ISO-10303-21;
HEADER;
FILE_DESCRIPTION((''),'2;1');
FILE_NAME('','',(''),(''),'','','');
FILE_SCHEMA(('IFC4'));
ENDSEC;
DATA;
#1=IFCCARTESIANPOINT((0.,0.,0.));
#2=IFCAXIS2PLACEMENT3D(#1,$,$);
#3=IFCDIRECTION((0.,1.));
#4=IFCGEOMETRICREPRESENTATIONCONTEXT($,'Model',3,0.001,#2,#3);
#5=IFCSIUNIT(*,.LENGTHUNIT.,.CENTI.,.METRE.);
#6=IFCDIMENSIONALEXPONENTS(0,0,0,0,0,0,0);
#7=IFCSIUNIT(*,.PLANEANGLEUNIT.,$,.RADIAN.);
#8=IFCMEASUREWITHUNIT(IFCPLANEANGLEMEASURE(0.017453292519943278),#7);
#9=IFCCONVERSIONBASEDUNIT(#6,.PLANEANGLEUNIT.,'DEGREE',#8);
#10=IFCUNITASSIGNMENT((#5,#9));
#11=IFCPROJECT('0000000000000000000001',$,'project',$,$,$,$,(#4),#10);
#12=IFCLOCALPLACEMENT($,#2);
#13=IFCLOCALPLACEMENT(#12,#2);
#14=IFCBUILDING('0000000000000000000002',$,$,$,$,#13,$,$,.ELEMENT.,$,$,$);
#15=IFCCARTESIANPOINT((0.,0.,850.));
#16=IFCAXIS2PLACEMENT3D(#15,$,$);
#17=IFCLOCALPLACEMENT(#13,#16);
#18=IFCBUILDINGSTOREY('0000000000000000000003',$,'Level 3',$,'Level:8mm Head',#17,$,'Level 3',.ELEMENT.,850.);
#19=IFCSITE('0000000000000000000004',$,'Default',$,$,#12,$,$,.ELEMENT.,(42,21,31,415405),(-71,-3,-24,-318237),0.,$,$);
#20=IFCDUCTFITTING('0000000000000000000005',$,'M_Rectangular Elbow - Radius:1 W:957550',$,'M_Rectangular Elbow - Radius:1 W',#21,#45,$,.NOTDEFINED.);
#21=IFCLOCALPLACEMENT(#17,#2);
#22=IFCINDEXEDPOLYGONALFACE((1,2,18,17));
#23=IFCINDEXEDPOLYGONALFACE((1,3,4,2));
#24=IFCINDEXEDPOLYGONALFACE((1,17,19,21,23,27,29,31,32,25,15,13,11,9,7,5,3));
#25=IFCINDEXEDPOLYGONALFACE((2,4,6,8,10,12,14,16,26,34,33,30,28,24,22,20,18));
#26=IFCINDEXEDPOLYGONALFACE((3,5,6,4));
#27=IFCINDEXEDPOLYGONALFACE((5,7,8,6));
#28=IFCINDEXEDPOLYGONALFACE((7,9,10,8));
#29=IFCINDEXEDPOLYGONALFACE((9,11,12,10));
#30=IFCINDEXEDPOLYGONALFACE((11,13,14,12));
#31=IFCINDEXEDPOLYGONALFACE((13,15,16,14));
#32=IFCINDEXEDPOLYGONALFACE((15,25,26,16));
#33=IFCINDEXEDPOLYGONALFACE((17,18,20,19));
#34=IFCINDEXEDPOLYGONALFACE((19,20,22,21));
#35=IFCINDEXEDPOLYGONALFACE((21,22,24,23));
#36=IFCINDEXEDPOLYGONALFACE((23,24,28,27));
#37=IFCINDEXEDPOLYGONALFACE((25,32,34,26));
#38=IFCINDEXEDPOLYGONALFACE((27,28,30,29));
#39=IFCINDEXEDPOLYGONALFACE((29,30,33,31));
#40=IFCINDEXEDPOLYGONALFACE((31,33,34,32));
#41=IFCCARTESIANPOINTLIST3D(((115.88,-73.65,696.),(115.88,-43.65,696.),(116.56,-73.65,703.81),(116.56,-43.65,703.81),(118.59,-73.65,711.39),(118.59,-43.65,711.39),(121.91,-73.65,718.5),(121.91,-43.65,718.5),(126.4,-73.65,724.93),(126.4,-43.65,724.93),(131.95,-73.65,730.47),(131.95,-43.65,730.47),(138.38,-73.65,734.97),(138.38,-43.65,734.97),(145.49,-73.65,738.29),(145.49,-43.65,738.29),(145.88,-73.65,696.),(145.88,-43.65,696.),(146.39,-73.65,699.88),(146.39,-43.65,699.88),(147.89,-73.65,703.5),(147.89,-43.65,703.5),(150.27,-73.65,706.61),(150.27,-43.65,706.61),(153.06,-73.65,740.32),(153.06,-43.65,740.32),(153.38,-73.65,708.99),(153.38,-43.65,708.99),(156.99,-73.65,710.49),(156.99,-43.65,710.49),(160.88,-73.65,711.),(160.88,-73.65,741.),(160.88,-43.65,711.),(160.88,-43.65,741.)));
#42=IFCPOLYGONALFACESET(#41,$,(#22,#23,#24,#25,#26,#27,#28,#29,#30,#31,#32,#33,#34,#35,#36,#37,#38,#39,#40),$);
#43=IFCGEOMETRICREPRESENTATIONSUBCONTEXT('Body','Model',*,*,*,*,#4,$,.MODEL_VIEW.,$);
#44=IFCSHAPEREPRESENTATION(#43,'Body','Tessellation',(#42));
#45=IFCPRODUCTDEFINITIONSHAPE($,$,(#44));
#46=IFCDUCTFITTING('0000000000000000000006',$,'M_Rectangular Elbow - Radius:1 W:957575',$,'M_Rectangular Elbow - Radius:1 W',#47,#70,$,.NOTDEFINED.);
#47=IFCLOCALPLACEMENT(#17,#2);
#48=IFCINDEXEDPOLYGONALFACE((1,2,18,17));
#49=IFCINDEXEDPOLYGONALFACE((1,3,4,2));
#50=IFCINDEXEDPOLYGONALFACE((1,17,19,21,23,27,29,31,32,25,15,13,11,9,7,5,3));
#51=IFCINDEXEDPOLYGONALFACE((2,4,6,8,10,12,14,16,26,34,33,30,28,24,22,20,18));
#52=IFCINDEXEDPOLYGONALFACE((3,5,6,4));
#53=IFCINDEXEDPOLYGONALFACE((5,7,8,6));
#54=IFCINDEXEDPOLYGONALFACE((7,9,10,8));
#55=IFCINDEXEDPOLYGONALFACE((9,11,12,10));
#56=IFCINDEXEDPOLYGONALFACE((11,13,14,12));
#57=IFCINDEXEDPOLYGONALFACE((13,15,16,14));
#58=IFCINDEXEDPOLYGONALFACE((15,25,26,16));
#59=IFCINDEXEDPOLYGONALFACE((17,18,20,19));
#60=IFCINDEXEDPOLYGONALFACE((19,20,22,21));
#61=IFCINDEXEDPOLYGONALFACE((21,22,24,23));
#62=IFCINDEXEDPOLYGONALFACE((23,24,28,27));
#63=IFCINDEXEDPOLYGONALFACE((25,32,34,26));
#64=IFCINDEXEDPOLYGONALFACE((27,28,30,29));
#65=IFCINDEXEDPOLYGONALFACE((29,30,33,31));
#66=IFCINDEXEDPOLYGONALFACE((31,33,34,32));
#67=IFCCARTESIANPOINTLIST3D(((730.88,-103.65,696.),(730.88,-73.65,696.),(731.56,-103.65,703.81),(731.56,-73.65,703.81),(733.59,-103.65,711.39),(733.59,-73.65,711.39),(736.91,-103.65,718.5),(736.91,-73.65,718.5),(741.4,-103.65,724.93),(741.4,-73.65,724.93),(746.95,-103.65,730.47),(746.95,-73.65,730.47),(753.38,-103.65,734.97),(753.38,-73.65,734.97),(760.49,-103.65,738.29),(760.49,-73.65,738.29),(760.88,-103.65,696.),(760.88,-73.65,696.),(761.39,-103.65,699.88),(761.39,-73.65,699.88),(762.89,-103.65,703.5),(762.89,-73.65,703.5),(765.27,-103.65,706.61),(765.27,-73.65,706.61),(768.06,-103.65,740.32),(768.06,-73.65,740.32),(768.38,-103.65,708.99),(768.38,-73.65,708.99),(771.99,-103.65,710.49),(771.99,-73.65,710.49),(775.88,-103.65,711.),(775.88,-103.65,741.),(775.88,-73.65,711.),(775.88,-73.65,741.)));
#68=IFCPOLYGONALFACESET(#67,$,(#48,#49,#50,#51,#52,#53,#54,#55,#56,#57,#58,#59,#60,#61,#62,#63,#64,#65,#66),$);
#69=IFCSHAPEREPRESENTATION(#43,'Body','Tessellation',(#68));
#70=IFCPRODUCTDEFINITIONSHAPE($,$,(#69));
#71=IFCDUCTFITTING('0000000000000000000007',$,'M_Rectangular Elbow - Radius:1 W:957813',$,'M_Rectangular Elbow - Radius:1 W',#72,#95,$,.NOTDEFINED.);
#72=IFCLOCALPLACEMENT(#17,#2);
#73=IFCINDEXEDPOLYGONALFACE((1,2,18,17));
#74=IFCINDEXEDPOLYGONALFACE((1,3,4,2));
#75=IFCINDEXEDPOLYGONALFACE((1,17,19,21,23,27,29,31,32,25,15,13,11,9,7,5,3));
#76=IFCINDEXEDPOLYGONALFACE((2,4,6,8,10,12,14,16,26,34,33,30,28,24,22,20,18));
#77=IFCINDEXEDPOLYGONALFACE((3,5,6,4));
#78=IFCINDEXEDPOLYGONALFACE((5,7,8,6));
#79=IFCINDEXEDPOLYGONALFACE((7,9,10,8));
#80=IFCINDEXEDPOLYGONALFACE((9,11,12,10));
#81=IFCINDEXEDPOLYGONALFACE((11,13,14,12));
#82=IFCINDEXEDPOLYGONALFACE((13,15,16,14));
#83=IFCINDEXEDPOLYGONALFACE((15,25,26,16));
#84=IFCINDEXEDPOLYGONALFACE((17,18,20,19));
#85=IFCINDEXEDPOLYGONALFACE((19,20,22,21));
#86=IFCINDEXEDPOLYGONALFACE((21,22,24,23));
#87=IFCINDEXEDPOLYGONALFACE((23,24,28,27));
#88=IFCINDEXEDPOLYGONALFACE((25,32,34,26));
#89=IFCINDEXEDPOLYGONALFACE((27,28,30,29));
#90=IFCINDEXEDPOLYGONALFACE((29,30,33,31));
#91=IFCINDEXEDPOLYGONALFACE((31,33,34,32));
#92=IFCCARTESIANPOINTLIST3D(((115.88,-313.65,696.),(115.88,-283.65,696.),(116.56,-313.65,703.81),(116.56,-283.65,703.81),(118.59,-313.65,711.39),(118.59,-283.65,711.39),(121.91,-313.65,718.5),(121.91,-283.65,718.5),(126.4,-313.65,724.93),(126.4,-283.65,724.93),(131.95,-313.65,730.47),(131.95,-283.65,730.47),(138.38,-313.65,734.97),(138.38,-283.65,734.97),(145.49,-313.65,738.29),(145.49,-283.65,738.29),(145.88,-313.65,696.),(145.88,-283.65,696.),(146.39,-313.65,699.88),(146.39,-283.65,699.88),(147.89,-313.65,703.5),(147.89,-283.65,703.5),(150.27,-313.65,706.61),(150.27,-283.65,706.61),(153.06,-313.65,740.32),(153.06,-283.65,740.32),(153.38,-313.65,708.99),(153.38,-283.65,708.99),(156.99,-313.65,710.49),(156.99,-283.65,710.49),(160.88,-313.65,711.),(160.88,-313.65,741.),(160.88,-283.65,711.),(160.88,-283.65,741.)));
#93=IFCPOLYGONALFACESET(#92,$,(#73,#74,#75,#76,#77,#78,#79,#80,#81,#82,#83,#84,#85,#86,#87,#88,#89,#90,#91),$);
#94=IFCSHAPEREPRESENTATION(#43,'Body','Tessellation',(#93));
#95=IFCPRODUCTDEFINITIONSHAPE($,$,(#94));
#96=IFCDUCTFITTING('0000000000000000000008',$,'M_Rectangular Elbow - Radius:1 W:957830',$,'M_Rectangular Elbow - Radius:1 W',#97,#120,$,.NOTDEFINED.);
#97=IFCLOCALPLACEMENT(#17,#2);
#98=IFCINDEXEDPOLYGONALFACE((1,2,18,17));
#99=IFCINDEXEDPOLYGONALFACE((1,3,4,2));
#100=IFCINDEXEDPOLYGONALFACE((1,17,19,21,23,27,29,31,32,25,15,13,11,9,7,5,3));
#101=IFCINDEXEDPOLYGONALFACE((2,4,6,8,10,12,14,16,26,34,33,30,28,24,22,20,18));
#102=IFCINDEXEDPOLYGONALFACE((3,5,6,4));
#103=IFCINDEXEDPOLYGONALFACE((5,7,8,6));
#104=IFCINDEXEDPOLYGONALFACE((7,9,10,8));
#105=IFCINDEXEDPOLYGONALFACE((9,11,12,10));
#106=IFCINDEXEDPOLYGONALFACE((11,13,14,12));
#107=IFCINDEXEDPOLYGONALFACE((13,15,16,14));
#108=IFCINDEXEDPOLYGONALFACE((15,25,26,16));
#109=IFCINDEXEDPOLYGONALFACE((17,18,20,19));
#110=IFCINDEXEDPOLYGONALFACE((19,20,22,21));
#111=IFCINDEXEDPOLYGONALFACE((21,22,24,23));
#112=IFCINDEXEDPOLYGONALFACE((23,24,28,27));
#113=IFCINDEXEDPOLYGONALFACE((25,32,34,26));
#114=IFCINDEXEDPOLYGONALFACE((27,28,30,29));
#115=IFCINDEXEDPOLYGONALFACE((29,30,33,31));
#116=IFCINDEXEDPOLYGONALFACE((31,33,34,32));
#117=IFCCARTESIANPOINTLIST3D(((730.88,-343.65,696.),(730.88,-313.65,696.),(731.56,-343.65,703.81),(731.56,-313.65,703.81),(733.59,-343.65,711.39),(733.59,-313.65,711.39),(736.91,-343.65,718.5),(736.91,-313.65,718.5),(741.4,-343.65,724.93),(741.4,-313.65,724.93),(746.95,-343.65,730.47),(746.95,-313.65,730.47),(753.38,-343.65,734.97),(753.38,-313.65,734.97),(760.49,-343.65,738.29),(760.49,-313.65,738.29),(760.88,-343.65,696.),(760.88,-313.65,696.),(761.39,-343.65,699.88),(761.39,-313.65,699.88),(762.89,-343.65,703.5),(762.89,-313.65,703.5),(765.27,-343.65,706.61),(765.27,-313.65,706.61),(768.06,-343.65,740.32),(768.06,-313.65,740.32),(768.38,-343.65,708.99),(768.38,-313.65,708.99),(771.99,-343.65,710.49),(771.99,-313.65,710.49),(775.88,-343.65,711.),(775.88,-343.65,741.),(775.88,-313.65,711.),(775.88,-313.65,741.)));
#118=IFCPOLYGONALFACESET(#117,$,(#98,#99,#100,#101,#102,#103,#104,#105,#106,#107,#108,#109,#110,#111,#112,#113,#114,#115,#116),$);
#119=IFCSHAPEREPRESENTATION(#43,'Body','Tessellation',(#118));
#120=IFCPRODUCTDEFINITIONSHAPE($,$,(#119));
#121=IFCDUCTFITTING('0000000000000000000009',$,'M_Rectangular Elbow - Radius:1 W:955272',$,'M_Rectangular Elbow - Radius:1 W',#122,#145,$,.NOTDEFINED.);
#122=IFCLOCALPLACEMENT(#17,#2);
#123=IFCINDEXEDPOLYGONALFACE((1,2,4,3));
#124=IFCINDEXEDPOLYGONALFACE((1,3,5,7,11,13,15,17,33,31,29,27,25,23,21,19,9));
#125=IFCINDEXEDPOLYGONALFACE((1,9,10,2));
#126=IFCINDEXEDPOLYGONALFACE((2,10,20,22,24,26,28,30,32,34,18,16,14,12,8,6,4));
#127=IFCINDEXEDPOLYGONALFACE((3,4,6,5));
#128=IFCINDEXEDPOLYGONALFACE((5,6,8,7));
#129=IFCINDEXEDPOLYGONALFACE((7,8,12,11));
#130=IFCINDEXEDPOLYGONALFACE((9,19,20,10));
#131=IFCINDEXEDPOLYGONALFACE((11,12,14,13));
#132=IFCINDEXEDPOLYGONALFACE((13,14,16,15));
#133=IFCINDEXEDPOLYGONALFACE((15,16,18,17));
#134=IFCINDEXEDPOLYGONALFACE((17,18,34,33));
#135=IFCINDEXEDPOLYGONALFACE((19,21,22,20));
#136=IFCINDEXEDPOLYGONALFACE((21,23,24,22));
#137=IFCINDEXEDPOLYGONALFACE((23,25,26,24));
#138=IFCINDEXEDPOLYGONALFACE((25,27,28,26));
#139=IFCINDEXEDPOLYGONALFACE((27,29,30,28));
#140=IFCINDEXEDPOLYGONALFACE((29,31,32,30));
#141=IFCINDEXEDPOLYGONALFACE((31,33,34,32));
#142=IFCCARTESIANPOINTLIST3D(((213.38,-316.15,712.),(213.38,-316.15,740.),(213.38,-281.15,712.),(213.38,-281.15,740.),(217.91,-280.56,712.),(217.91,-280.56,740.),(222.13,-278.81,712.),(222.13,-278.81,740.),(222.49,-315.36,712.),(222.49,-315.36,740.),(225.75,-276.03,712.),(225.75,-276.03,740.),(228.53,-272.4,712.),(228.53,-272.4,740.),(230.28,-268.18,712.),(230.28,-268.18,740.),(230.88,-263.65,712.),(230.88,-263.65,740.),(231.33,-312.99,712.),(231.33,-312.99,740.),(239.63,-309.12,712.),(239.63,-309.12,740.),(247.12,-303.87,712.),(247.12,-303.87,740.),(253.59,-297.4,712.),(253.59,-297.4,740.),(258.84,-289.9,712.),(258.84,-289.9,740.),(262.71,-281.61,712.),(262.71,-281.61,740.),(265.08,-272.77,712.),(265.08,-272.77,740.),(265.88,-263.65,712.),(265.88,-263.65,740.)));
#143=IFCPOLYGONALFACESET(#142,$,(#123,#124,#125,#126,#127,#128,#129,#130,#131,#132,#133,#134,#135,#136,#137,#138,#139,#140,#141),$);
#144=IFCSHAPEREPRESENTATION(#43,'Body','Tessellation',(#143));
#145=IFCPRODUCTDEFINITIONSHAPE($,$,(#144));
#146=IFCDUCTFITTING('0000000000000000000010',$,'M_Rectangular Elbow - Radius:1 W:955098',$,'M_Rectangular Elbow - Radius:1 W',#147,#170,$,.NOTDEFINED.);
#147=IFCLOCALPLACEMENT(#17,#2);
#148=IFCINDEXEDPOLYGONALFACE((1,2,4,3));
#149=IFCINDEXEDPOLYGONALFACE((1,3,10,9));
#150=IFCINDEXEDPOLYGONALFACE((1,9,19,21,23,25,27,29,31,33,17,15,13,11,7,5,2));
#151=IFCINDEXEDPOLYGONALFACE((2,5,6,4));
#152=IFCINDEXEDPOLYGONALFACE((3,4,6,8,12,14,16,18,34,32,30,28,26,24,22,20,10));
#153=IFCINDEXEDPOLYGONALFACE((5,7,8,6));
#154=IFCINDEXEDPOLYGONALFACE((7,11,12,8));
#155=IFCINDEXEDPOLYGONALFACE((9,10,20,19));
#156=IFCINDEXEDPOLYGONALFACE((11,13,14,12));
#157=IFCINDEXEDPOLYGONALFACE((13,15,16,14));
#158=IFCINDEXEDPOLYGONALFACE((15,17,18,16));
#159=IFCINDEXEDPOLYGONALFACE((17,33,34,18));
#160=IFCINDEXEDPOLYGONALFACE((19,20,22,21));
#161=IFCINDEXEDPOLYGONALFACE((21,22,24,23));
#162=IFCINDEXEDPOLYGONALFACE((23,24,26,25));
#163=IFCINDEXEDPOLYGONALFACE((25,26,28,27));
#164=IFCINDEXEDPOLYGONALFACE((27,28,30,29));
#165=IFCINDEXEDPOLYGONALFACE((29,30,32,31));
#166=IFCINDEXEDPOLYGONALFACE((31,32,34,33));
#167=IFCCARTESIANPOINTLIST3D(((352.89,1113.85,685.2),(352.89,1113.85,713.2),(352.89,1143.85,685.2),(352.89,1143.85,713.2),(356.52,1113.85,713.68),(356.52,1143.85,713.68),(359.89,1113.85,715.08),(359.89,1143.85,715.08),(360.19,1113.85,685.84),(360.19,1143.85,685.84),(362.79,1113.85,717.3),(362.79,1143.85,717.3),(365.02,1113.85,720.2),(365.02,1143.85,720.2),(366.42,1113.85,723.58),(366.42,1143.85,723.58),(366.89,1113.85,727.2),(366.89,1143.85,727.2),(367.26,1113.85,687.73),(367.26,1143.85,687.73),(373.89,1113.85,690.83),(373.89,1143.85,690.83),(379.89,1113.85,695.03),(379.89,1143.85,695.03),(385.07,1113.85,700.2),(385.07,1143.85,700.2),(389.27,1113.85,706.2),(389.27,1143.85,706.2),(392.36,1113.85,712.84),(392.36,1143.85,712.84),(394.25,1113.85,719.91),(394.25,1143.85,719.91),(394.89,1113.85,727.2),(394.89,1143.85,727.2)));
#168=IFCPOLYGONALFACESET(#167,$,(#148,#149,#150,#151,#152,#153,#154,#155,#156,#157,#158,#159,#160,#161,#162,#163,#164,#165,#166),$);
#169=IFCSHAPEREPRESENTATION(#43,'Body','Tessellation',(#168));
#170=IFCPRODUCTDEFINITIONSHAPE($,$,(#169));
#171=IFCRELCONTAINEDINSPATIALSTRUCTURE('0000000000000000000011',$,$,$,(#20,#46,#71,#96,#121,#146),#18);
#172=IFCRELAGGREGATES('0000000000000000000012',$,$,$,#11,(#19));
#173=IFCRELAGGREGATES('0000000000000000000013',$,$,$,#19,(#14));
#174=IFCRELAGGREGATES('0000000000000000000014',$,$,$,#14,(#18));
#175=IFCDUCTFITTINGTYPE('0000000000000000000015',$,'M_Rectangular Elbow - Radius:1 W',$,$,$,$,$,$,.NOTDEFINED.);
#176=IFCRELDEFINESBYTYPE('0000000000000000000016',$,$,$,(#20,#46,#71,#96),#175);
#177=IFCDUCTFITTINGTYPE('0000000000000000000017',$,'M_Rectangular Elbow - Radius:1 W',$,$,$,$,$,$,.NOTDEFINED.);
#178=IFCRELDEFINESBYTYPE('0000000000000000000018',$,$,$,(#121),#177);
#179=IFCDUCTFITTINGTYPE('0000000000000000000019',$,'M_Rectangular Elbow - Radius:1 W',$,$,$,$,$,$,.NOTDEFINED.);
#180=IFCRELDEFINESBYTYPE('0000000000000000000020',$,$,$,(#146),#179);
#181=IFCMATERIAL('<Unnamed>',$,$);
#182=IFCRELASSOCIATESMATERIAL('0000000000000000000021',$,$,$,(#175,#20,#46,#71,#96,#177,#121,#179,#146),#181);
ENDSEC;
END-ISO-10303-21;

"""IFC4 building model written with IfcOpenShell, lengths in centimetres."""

from ifc_helpers import new_model, entity, si_unit, converted_unit, direction, frame, origin, place, context, subcontext, project, spatial, line, arc, indexed_curve, outline, extrude, source, transform, mapped, material, type_object, type_shapes, element, save


model = new_model("IFC4")

# Units and contexts
model_context = context("Model", 3, precision=0.001, world=origin(), true_north=direction((0.0, 1.0)))
body_context = subcontext(model_context, "Body", "Model", "MODEL_VIEW")
ifc_project = project(units=[si_unit("LENGTHUNIT", "METRE", prefix="CENTI"), converted_unit("PLANEANGLEUNIT", "DEGREE", entity("IfcPlaneAngleMeasure", 0.017453292519943278), si_unit("PLANEANGLEUNIT", "RADIAN"), dimensions=[0, 0, 0, 0, 0, 0, 0])], contexts=[model_context])

# Site, building, storey
site_placement = place(None, origin())
site = spatial("IfcSite", under=ifc_project, at=site_placement, Name="Default", CompositionType="ELEMENT", RefLatitude=(42, 21, 31, 415405), RefLongitude=(-71, -3, -24, -318237), RefElevation=0.0)
building_placement = place(site_placement, origin())
building = spatial("IfcBuilding", under=site, at=building_placement, CompositionType="ELEMENT")
storey_placement = place(building_placement, frame((0.0, 0.0, 850.0)))
storey = spatial("IfcBuildingStorey", under=building, at=storey_placement, Name="Level 3", ObjectType="Level:8mm Head", LongName="Level 3", CompositionType="ELEMENT", Elevation=850.0)

# Duct fittings
ifc_material = material(Name="<Unnamed>")
duct_fitting_type_1 = type_object("IfcDuctFittingType", Name="M_Rectangular Elbow - Radius:1 W", PredefinedType="NOTDEFINED", material=ifc_material)
shared_shape_1 = source(origin(), body_context, "Body", "SweptSolid", [
    extrude(outline(indexed_curve([(-30.0, -15.0), (0.0, -15.0), (4.39, -4.39), (15.0, 0.0), (15.0, 30.0), (-16.82, 16.82)], segments=[line(1, 2), arc(2, 3, 4), line(4, 5), arc(5, 6, 1)], self_intersect=False)), frame((-15.0, 15.0, -15.0), z_axis=(0.0, 0.0, 1.0), x_axis=(-1.0, 0.0, 0.0)), (0.0, 0.0, 1.0), 30.0),
])
type_shapes(duct_fitting_type_1, [shared_shape_1])
for number, where, z_axis, x_axis, name in (
    (1, (130.88, -58.65, 726.0), (0.0, -1.0, 0.0), (-1.0, 0.0, 0.0), "M_Rectangular Elbow - Radius:1 W:957550"),
    (2, (745.88, -88.65, 726.0), (0.0, -1.0, 0.0), (-1.0, 0.0, 0.0), "M_Rectangular Elbow - Radius:1 W:957575"),
    (3, (130.88, -298.65, 726.0), (0.0, -1.0, 0.0), (-1.0, 0.0, 0.0), "M_Rectangular Elbow - Radius:1 W:957813"),
    (4, (745.88, -328.65, 726.0), (0.0, -1.0, 0.0), (-1.0, 0.0, 0.0), "M_Rectangular Elbow - Radius:1 W:957830"),
):
    element("IfcDuctFitting", number, at=place(storey_placement, frame(where, z_axis=z_axis, x_axis=x_axis)), inside=storey, type_object=duct_fitting_type_1, material=ifc_material, Name=name, ObjectType="M_Rectangular Elbow - Radius:1 W", PredefinedType="NOTDEFINED", context=body_context, shape_type="MappedRepresentation", body=[
        mapped(shared_shape_1, transform((0.0, 0.0, 0.0), scale=1.0)),
    ])
duct_fitting_type_2 = type_object("IfcDuctFittingType", Name="M_Rectangular Elbow - Radius:1 W", PredefinedType="NOTDEFINED", material=ifc_material)
shared_shape_2 = source(origin(), body_context, "Body", "SweptSolid", [
    extrude(outline(indexed_curve([(-35.0, -17.5), (0.0, -17.5), (5.13, -5.13), (17.5, 0.0), (17.5, 35.0), (-19.62, 19.62)], segments=[line(1, 2), arc(2, 3, 4), line(4, 5), arc(5, 6, 1)], self_intersect=False)), frame((-17.5, 17.5, -14.0), z_axis=(0.0, 0.0, 1.0), x_axis=(-1.0, 0.0, 0.0)), (0.0, 0.0, 1.0), 28.0),
])
type_shapes(duct_fitting_type_2, [shared_shape_2])
duct_fitting_1_placement = place(storey_placement, frame((248.38, -298.65, 726.0)))
element("IfcDuctFitting", 5, at=duct_fitting_1_placement, inside=storey, type_object=duct_fitting_type_2, material=ifc_material, Name="M_Rectangular Elbow - Radius:1 W:955272", ObjectType="M_Rectangular Elbow - Radius:1 W", PredefinedType="NOTDEFINED", context=body_context, shape_type="MappedRepresentation", body=[
    mapped(shared_shape_2, transform((0.0, 0.0, 0.0), scale=1.0)),
])
duct_fitting_type_3 = type_object("IfcDuctFittingType", Name="M_Rectangular Elbow - Radius:1 W", PredefinedType="NOTDEFINED", material=ifc_material)
shared_shape_3 = source(origin(), body_context, "Body", "SweptSolid", [
    extrude(outline(indexed_curve([(-14.0, -28.0), (15.7, -15.7), (28.0, 14.0), (0.0, 14.0), (-4.1, 4.1), (-14.0, 0.0)], segments=[arc(1, 2, 3), line(3, 4), arc(4, 5, 6), line(6, 1)], self_intersect=False)), frame((-14.0, -14.0, -15.0), z_axis=(0.0, 0.0, 1.0), x_axis=(0.0, 1.0, 0.0)), (0.0, 0.0, 1.0), 30.0),
])
type_shapes(duct_fitting_type_3, [shared_shape_3])
duct_fitting_2_placement = place(storey_placement, frame((380.89, 1128.85, 699.2), z_axis=(0.0, -1.0, 0.0), x_axis=(0.0, 0.0, -1.0)))
element("IfcDuctFitting", 6, at=duct_fitting_2_placement, inside=storey, type_object=duct_fitting_type_3, material=ifc_material, Name="M_Rectangular Elbow - Radius:1 W:955098", ObjectType="M_Rectangular Elbow - Radius:1 W", PredefinedType="NOTDEFINED", context=body_context, shape_type="MappedRepresentation", body=[
    mapped(shared_shape_3, transform((0.0, 0.0, 0.0), scale=1.0)),
])

save(model, "model.ifc")
